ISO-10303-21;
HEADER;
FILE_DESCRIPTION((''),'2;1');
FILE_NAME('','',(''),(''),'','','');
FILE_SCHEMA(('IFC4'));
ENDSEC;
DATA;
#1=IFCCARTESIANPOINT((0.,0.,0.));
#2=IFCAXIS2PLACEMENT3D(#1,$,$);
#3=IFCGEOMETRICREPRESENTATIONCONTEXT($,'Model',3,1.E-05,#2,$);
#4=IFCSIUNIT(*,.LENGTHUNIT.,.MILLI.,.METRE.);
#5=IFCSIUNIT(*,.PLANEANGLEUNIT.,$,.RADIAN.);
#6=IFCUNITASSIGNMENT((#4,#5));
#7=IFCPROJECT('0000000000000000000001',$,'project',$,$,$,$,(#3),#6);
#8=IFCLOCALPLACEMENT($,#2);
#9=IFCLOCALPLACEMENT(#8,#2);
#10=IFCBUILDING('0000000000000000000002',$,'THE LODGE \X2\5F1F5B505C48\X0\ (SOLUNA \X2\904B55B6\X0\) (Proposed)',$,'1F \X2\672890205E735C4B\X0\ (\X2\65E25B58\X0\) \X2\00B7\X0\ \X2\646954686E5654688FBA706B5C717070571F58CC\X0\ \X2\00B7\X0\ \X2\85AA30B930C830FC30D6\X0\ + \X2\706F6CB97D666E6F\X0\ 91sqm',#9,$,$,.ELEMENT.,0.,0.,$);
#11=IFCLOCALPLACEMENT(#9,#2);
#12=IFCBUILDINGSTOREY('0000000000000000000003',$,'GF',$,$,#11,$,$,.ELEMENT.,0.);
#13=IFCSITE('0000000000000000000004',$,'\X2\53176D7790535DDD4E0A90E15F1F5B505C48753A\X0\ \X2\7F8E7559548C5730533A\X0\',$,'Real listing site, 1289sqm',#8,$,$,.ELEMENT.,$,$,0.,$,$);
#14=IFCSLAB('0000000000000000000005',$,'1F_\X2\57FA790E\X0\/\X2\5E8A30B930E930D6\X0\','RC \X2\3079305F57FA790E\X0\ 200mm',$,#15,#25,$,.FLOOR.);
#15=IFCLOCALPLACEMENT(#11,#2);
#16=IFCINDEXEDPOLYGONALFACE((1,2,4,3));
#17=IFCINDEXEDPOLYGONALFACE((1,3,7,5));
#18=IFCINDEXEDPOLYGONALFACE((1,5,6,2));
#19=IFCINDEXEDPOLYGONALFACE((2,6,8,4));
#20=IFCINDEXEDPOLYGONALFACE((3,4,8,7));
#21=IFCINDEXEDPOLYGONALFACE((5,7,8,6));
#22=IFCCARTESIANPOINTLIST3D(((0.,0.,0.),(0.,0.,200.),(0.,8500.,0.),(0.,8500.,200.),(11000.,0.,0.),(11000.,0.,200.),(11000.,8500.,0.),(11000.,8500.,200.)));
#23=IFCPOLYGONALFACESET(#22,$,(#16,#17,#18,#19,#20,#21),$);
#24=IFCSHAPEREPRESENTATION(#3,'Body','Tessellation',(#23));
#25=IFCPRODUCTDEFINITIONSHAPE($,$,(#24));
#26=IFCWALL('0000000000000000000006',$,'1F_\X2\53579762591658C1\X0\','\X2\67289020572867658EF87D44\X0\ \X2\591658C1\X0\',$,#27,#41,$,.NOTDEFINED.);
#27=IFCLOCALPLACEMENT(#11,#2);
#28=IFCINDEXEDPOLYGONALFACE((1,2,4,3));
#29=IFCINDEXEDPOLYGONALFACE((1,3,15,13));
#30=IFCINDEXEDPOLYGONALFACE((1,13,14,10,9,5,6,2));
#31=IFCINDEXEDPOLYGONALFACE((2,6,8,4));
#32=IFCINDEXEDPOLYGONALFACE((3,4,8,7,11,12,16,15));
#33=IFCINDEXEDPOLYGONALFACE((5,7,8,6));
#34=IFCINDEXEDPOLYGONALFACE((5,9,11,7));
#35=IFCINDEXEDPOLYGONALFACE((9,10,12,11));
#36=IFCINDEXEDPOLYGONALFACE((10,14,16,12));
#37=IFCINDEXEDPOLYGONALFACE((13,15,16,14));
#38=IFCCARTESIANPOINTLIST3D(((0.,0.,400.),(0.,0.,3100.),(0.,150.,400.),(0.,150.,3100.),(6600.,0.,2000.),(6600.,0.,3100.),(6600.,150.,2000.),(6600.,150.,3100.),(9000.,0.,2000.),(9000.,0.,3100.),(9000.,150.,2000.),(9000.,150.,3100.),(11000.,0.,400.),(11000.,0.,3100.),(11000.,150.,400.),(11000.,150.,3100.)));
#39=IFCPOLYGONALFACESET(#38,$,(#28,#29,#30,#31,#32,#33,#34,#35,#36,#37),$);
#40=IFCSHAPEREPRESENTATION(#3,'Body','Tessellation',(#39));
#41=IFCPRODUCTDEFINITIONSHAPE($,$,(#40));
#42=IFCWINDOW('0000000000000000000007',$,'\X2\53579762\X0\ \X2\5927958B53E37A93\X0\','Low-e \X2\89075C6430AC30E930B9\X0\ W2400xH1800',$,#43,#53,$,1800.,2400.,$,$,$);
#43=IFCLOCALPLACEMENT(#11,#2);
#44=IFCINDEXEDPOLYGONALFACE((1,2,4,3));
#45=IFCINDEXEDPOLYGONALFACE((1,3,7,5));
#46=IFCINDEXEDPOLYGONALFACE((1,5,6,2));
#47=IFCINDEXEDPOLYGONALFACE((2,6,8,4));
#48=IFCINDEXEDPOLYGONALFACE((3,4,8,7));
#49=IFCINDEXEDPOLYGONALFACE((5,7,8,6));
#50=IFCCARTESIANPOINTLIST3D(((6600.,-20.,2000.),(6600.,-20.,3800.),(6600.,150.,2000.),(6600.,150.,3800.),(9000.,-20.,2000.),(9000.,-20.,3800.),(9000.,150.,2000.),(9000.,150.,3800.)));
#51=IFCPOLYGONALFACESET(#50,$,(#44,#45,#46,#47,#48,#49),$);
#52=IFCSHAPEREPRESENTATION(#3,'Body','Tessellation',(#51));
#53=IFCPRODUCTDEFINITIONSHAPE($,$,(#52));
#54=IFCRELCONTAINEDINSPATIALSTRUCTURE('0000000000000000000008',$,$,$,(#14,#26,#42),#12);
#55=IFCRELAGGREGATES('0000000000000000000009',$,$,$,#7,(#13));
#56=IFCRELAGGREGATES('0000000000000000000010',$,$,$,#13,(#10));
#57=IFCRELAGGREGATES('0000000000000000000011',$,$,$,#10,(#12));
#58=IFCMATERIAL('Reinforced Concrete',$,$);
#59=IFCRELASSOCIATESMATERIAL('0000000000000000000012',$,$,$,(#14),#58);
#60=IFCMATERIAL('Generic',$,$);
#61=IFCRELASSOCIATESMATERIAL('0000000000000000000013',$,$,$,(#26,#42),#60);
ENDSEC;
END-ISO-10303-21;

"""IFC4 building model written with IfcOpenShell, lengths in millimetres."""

from ifc_helpers import new_model, si_unit, frame, frame_2d, origin, place, context, project, spatial, rectangle, extrude, material, element, fill, save


model = new_model("IFC4")

# Units and contexts
model_context = context("Model", 3, precision=1e-05, world=origin())
ifc_project = project(units=[si_unit("LENGTHUNIT", "METRE", prefix="MILLI"), si_unit("PLANEANGLEUNIT", "RADIAN")], contexts=[model_context])

# Site, building, storey
site_placement = place(None, origin())
site = spatial("IfcSite", under=ifc_project, at=site_placement, Name="北海道川上郡弟子屈町 美留和地区", ObjectType="Real listing site, 1289sqm", CompositionType="ELEMENT", RefElevation=0.0)
building_placement = place(site_placement, origin())
building = spatial("IfcBuilding", under=site, at=building_placement, Name="THE LODGE 弟子屈 (SOLUNA 運営) (Proposed)", ObjectType="1F 木造平屋 (既存) · 摩周湖周辺火山灰土壌 · 薪ストーブ + 灯油給湯 91sqm", CompositionType="ELEMENT", ElevationOfRefHeight=0.0, ElevationOfTerrain=0.0)
storey_placement = place(building_placement, origin())
storey = spatial("IfcBuildingStorey", under=building, at=storey_placement, Name="GF", CompositionType="ELEMENT", Elevation=0.0)

# Slab
ifc_material_1 = material(Name="Reinforced Concrete")
slab_placement = place(storey_placement, origin())
element("IfcSlab", 1, at=slab_placement, inside=storey, material=ifc_material_1, Name="1F_基礎/床スラブ", Description="RC べた基礎 200mm", PredefinedType="FLOOR", context=model_context, shape_type="SweptSolid", body=[
    extrude(rectangle(XDim=11000.0, YDim=8500.0, at=frame_2d((5500.0, 4250.0))), origin(), (0.0, 0.0, 1.0), 200.0),
])

# Wall, opening, window
ifc_material_2 = material(Name="Generic")
wall_1_placement = place(storey_placement, frame((0.0, 0.0, 200.0)))
wall_1 = element("IfcWall", 2, at=wall_1_placement, inside=storey, material=ifc_material_2, Name="1F_南面外壁", Description="木造在来軸組 外壁", PredefinedType="NOTDEFINED", context=model_context, shape_type="SweptSolid", body=[
    extrude(rectangle(XDim=11000.0, YDim=150.0, at=frame_2d((5500.0, 75.0))), frame((0.0, 0.0, 200.0)), (0.0, 0.0, 1.0), 2700.0),
])
opening_1_placement = place(storey_placement, frame((3300.0, -10.0, 1000.0)))
opening_1 = element("IfcOpeningElement", 3, at=opening_1_placement, cuts=wall_1, PredefinedType="NOTDEFINED", context=model_context, shape_type="SweptSolid", body=[
    extrude(rectangle(XDim=2400.0, YDim=170.0, at=frame_2d((1200.0, 85.0))), frame((3300.0, -10.0, 1000.0)), (0.0, 0.0, 1.0), 1800.0),
])
window_1_placement = place(storey_placement, frame((3300.0, -10.0, 1000.0)))
window_1 = element("IfcWindow", 4, at=window_1_placement, inside=storey, material=ifc_material_2, Name="南面 大開口窓", Description="Low-e 複層ガラス W2400xH1800", OverallHeight=1800.0, OverallWidth=2400.0, context=model_context, shape_type="SweptSolid", body=[
    extrude(rectangle(XDim=2400.0, YDim=170.0, at=frame_2d((1200.0, 85.0))), frame((3300.0, -10.0, 1000.0)), (0.0, 0.0, 1.0), 1800.0),
])
fill(opening_1, window_1)

save(model, "model.ifc")
